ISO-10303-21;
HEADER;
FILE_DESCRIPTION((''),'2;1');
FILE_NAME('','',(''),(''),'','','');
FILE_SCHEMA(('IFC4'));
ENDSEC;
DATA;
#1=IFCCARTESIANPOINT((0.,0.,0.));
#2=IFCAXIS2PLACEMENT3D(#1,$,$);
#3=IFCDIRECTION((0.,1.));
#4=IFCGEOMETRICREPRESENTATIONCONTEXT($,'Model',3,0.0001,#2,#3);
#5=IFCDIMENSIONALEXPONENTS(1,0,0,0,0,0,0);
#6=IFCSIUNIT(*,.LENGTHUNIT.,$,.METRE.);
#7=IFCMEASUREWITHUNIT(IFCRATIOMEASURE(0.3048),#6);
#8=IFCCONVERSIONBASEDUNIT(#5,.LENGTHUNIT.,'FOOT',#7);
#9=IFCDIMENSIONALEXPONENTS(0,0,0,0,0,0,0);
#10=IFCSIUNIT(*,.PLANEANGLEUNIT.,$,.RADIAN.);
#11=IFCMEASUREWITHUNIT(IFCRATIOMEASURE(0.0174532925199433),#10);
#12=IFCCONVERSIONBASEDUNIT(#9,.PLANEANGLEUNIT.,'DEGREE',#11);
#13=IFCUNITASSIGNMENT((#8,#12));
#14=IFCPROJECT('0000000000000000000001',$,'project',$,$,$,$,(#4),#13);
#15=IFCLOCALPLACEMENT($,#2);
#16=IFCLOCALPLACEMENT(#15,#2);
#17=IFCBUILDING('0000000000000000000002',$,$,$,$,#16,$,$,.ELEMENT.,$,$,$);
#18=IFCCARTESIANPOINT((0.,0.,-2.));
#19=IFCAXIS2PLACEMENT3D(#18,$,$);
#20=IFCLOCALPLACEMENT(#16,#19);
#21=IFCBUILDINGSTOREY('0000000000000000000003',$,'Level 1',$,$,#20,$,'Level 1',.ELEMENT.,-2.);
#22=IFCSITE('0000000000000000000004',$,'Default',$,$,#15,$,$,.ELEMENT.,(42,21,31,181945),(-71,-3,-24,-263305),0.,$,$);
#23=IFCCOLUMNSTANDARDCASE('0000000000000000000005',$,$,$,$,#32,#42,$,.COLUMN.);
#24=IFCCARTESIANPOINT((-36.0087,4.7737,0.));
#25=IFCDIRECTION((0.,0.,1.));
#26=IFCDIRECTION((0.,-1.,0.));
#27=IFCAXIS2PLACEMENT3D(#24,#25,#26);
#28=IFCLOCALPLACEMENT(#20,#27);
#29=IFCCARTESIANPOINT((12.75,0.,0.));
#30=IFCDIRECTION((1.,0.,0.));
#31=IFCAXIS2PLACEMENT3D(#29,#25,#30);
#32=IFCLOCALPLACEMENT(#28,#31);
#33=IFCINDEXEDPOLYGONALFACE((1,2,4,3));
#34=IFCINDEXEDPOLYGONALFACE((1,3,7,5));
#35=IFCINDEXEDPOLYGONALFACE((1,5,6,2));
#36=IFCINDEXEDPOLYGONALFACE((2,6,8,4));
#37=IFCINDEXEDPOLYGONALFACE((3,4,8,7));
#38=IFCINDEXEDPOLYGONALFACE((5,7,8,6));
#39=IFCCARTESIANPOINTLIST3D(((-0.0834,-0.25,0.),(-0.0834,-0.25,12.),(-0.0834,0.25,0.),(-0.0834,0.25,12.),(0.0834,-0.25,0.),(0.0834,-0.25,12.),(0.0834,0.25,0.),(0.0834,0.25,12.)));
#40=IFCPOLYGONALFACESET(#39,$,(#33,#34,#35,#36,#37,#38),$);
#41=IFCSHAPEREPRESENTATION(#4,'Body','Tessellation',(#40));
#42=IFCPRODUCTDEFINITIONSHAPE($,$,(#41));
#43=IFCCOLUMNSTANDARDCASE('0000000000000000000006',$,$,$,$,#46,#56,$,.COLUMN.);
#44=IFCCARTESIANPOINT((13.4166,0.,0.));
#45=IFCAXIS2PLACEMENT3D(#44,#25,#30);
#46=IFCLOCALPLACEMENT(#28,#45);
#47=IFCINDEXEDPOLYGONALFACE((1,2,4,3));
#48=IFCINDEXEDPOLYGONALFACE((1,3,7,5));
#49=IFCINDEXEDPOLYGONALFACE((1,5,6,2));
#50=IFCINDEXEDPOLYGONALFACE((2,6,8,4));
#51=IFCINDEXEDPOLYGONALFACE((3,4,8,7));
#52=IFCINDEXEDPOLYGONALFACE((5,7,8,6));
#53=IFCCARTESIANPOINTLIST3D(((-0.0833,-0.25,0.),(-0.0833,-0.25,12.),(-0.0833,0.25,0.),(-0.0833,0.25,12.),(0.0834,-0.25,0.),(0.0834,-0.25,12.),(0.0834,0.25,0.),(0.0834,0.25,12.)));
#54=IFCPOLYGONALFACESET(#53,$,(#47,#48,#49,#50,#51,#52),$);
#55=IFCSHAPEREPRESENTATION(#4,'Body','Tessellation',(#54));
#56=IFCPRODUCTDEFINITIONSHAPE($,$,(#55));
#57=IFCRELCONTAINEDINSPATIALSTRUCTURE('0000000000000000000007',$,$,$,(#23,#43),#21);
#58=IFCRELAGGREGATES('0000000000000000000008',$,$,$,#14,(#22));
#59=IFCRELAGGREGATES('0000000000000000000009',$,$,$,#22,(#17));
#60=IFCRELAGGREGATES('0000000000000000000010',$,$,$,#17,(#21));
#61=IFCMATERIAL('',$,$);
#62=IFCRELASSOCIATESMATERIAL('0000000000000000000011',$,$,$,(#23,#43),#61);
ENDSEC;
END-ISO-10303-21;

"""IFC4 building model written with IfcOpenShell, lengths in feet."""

from ifc_helpers import new_model, entity, si_unit, converted_unit, direction, frame, origin, place, context, project, spatial, rectangle, extrude, material, element, save


model = new_model("IFC4")

# Units and contexts
model_context = context("Model", 3, precision=0.0001, world=origin(), true_north=direction((0.0, 1.0)))
ifc_project = project(units=[converted_unit("LENGTHUNIT", "FOOT", entity("IfcRatioMeasure", 0.3048), si_unit("LENGTHUNIT", "METRE"), dimensions=[1, 0, 0, 0, 0, 0, 0]), converted_unit("PLANEANGLEUNIT", "DEGREE", entity("IfcRatioMeasure", 0.0174532925199433), si_unit("PLANEANGLEUNIT", "RADIAN"), dimensions=[0, 0, 0, 0, 0, 0, 0])], contexts=[model_context])

# Site, building, storey
site_placement = place(None, origin())
site = spatial("IfcSite", under=ifc_project, at=site_placement, Name="Default", CompositionType="ELEMENT", RefLatitude=(42, 21, 31, 181945), RefLongitude=(-71, -3, -24, -263305), RefElevation=0.0)
building_placement = place(site_placement, origin())
building = spatial("IfcBuilding", under=site, at=building_placement, CompositionType="ELEMENT")
storey_placement = place(building_placement, frame((0.0, 0.0, -2.0)))
storey = spatial("IfcBuildingStorey", under=building, at=storey_placement, Name="Level 1", LongName="Level 1", CompositionType="ELEMENT", Elevation=-2.0)

# Columns
ifc_material_1 = material(Name="")
placement = place(storey_placement, frame((-36.0087, 4.7737, 0.0), z_axis=(0.0, 0.0, 1.0), x_axis=(0.0, -1.0, 0.0)))
for number, where, z_axis, x_axis in (
    (1, (12.75, 0.0, 0.0), (0.0, 0.0, 1.0), (1.0, 0.0, 0.0)),
    (2, (13.4166, 0.0, 0.0), (0.0, 0.0, 1.0), (1.0, 0.0, 0.0)),
):
    element("IfcColumnStandardCase", number, at=place(placement, frame(where, z_axis=z_axis, x_axis=x_axis)), inside=storey, material=ifc_material_1, PredefinedType="COLUMN", context=model_context, shape_type="SweptSolid", body=[
        extrude(rectangle(XDim=0.1667, YDim=0.5), origin(), (0.0, 0.0, 1.0), 12.0),
    ])

save(model, "model.ifc")
